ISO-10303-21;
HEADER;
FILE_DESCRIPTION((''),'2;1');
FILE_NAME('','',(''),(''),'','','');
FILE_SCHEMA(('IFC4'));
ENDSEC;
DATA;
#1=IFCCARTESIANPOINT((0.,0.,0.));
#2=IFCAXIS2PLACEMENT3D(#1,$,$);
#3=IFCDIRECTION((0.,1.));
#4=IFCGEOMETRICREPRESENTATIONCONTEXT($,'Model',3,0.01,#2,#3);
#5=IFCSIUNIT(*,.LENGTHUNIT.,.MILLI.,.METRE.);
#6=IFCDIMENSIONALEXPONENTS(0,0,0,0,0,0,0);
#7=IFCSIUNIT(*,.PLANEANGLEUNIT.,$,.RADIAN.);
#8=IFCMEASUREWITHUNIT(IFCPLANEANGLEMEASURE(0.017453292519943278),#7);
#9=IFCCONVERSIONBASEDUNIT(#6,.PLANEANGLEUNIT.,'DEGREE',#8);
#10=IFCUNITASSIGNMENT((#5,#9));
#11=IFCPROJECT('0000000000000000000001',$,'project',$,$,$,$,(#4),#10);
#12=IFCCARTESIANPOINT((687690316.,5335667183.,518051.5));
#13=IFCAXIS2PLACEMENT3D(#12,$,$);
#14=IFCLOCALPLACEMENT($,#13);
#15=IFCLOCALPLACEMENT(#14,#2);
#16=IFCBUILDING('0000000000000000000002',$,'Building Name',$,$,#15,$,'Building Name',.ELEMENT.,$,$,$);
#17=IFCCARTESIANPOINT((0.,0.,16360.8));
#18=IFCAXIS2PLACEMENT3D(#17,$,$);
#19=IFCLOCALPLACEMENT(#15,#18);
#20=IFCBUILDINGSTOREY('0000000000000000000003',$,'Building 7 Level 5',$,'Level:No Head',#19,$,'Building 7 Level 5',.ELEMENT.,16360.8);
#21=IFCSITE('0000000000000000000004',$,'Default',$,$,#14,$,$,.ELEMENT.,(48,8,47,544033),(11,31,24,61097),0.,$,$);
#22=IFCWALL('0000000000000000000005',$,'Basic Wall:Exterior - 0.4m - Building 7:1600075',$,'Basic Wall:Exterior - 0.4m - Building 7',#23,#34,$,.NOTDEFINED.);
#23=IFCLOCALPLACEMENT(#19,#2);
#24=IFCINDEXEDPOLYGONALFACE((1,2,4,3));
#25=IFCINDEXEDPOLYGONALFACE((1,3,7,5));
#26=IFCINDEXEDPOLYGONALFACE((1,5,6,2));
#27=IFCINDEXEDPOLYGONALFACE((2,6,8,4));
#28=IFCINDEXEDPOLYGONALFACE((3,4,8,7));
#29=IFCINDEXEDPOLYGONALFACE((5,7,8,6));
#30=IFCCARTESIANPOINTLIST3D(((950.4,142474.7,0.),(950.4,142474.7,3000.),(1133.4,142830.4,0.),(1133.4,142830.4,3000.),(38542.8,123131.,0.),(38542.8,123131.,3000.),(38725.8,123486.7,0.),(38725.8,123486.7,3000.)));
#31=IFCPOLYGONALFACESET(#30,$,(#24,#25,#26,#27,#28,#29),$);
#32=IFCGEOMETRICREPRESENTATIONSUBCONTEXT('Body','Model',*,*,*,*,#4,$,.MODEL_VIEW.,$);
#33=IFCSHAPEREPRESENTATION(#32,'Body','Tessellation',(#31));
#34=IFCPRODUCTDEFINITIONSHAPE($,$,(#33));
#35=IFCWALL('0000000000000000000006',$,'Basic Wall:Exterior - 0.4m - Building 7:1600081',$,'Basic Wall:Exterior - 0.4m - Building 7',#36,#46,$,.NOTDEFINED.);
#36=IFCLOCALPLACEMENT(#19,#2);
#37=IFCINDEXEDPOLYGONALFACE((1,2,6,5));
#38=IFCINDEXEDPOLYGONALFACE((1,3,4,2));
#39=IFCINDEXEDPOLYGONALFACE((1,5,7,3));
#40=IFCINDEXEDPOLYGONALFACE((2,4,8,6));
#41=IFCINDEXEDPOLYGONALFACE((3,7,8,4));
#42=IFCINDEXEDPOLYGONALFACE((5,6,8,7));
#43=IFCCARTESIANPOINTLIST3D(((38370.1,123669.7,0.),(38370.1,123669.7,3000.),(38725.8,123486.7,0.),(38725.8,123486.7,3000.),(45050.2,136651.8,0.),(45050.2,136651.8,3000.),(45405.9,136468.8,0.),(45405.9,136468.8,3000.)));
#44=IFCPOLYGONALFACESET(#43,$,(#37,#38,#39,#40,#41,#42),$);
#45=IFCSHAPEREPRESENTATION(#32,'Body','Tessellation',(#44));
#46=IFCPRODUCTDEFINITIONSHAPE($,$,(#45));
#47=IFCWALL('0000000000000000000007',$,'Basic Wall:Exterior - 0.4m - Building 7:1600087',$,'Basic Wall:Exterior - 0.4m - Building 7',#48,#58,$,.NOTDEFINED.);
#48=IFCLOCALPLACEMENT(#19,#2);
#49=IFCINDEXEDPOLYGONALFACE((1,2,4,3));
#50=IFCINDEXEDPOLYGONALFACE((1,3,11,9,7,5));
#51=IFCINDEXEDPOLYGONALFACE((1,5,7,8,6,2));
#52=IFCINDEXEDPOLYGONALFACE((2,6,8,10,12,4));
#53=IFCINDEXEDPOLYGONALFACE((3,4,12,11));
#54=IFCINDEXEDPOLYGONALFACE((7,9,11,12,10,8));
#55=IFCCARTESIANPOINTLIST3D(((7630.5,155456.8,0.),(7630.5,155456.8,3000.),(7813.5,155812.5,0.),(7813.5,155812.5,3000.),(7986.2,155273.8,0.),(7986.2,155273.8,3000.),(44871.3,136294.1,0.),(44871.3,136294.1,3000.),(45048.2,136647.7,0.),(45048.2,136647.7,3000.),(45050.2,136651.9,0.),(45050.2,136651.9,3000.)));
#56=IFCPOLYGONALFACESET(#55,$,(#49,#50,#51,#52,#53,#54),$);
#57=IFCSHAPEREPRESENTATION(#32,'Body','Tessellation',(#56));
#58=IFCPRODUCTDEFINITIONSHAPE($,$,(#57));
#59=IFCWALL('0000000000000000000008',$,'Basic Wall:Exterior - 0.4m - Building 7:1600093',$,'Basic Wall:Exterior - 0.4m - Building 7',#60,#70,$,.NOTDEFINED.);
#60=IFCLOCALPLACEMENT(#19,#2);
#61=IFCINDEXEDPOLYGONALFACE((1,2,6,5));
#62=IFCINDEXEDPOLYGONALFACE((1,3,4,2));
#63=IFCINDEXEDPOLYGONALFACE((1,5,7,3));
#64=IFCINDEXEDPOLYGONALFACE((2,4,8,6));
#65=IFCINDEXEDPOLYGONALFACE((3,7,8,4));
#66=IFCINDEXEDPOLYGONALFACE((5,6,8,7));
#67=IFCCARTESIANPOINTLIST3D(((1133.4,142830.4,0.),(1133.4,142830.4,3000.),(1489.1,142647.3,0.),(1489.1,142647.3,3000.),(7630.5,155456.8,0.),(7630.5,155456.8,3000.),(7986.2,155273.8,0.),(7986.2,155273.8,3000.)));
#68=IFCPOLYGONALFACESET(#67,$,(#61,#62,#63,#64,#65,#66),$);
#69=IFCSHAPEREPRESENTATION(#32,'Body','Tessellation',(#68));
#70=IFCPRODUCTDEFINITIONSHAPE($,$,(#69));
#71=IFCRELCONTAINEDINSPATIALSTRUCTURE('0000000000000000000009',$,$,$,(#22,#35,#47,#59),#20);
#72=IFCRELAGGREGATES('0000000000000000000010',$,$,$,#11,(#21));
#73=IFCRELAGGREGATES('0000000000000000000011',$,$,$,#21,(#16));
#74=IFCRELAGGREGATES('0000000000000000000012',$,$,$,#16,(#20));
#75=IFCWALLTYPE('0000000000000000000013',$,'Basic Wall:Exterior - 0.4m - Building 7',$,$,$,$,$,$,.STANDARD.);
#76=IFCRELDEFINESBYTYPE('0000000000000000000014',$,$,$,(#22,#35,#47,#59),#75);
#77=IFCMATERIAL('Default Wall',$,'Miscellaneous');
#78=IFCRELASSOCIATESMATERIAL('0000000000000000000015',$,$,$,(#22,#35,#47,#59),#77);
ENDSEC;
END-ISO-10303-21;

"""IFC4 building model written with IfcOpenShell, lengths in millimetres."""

from ifc_helpers import new_model, entity, si_unit, converted_unit, direction, frame, origin, place, context, subcontext, project, spatial, indexed_curve, outline, extrude, material, type_object, element, save


model = new_model("IFC4")

# Units and contexts
model_context = context("Model", 3, precision=0.01, world=origin(), true_north=direction((0.0, 1.0)))
body_context = subcontext(model_context, "Body", "Model", "MODEL_VIEW")
ifc_project = project(units=[si_unit("LENGTHUNIT", "METRE", prefix="MILLI"), converted_unit("PLANEANGLEUNIT", "DEGREE", entity("IfcPlaneAngleMeasure", 0.017453292519943278), si_unit("PLANEANGLEUNIT", "RADIAN"), dimensions=[0, 0, 0, 0, 0, 0, 0])], contexts=[model_context])

# Site, building, storey
site_placement = place(None, frame((687690316.0, 5335667183.0, 518051.5)))
site = spatial("IfcSite", under=ifc_project, at=site_placement, Name="Default", CompositionType="ELEMENT", RefLatitude=(48, 8, 47, 544033), RefLongitude=(11, 31, 24, 61097), RefElevation=0.0)
building_placement = place(site_placement, origin())
building = spatial("IfcBuilding", under=site, at=building_placement, Name="Building Name", LongName="Building Name", CompositionType="ELEMENT")
storey_placement = place(building_placement, frame((0.0, 0.0, 16360.8)))
storey = spatial("IfcBuildingStorey", under=building, at=storey_placement, Name="Building 7 Level 5", ObjectType="Level:No Head", LongName="Building 7 Level 5", CompositionType="ELEMENT", Elevation=16360.8)

# Walls
ifc_material_1 = material(Name="Default Wall", Category="Miscellaneous")
wall_type = type_object("IfcWallType", Name="Basic Wall:Exterior - 0.4m - Building 7", PredefinedType="STANDARD")
wall_1_placement = place(storey_placement, frame((1041.9, 142652.5, 0.0), z_axis=(0.0, 0.0, 1.0), x_axis=(0.889187, -0.457543, 0.0)))
element("IfcWall", 1, at=wall_1_placement, inside=storey, type_object=wall_type, material=ifc_material_1, Name="Basic Wall:Exterior - 0.4m - Building 7:1600075", ObjectType="Basic Wall:Exterior - 0.4m - Building 7", PredefinedType="NOTDEFINED", context=body_context, shape_type="SweptSolid", body=[
    extrude(outline(indexed_curve([(42277.2, 200.0), (0.0, 200.0), (0.0, -200.0), (42277.2, -200.0), (42277.2, 200.0)], self_intersect=False)), origin(), (0.0, 0.0, 1.0), 3000.0),
])
wall_2_placement = place(storey_placement, frame((38548.0, 123578.2, 0.0), z_axis=(0.0, 0.0, 1.0), x_axis=(0.457543, 0.889187, 0.0)))
element("IfcWall", 2, at=wall_2_placement, inside=storey, type_object=wall_type, material=ifc_material_1, Name="Basic Wall:Exterior - 0.4m - Building 7:1600081", ObjectType="Basic Wall:Exterior - 0.4m - Building 7", PredefinedType="NOTDEFINED", context=body_context, shape_type="SweptSolid", body=[
    extrude(outline(indexed_curve([(14600.0, 200.0), (0.0, 200.0), (0.0, -200.0), (14600.0, -200.0), (14600.0, 200.0)], self_intersect=False)), origin(), (0.0, 0.0, 1.0), 3000.0),
])
wall_3_placement = place(storey_placement, frame((44962.8, 136471.9, 0.0), z_axis=(0.0, 0.0, 1.0), x_axis=(-0.889187, 0.457543, 0.0)))
element("IfcWall", 3, at=wall_3_placement, inside=storey, type_object=wall_type, material=ifc_material_1, Name="Basic Wall:Exterior - 0.4m - Building 7:1600087", ObjectType="Basic Wall:Exterior - 0.4m - Building 7", PredefinedType="NOTDEFINED", context=body_context, shape_type="SweptSolid", body=[
    extrude(outline(indexed_curve([(41881.8, -200.0), (41881.8, 200.0), (41481.8, 200.0), (0.0, 200.0), (4.6, -195.4), (4.6, -200.0), (41881.8, -200.0)], self_intersect=False)), origin(), (0.0, 0.0, 1.0), 3000.0),
])
wall_4_placement = place(storey_placement, frame((7808.3, 155365.3, 0.0), z_axis=(0.0, 0.0, 1.0), x_axis=(-0.457543, -0.889187, 0.0)))
element("IfcWall", 4, at=wall_4_placement, inside=storey, type_object=wall_type, material=ifc_material_1, Name="Basic Wall:Exterior - 0.4m - Building 7:1600093", ObjectType="Basic Wall:Exterior - 0.4m - Building 7", PredefinedType="NOTDEFINED", context=body_context, shape_type="SweptSolid", body=[
    extrude(outline(indexed_curve([(14200.0, 200.0), (0.0, 200.0), (0.0, -200.0), (14200.0, -200.0), (14200.0, 200.0)], self_intersect=False)), origin(), (0.0, 0.0, 1.0), 3000.0),
])

save(model, "model.ifc")
